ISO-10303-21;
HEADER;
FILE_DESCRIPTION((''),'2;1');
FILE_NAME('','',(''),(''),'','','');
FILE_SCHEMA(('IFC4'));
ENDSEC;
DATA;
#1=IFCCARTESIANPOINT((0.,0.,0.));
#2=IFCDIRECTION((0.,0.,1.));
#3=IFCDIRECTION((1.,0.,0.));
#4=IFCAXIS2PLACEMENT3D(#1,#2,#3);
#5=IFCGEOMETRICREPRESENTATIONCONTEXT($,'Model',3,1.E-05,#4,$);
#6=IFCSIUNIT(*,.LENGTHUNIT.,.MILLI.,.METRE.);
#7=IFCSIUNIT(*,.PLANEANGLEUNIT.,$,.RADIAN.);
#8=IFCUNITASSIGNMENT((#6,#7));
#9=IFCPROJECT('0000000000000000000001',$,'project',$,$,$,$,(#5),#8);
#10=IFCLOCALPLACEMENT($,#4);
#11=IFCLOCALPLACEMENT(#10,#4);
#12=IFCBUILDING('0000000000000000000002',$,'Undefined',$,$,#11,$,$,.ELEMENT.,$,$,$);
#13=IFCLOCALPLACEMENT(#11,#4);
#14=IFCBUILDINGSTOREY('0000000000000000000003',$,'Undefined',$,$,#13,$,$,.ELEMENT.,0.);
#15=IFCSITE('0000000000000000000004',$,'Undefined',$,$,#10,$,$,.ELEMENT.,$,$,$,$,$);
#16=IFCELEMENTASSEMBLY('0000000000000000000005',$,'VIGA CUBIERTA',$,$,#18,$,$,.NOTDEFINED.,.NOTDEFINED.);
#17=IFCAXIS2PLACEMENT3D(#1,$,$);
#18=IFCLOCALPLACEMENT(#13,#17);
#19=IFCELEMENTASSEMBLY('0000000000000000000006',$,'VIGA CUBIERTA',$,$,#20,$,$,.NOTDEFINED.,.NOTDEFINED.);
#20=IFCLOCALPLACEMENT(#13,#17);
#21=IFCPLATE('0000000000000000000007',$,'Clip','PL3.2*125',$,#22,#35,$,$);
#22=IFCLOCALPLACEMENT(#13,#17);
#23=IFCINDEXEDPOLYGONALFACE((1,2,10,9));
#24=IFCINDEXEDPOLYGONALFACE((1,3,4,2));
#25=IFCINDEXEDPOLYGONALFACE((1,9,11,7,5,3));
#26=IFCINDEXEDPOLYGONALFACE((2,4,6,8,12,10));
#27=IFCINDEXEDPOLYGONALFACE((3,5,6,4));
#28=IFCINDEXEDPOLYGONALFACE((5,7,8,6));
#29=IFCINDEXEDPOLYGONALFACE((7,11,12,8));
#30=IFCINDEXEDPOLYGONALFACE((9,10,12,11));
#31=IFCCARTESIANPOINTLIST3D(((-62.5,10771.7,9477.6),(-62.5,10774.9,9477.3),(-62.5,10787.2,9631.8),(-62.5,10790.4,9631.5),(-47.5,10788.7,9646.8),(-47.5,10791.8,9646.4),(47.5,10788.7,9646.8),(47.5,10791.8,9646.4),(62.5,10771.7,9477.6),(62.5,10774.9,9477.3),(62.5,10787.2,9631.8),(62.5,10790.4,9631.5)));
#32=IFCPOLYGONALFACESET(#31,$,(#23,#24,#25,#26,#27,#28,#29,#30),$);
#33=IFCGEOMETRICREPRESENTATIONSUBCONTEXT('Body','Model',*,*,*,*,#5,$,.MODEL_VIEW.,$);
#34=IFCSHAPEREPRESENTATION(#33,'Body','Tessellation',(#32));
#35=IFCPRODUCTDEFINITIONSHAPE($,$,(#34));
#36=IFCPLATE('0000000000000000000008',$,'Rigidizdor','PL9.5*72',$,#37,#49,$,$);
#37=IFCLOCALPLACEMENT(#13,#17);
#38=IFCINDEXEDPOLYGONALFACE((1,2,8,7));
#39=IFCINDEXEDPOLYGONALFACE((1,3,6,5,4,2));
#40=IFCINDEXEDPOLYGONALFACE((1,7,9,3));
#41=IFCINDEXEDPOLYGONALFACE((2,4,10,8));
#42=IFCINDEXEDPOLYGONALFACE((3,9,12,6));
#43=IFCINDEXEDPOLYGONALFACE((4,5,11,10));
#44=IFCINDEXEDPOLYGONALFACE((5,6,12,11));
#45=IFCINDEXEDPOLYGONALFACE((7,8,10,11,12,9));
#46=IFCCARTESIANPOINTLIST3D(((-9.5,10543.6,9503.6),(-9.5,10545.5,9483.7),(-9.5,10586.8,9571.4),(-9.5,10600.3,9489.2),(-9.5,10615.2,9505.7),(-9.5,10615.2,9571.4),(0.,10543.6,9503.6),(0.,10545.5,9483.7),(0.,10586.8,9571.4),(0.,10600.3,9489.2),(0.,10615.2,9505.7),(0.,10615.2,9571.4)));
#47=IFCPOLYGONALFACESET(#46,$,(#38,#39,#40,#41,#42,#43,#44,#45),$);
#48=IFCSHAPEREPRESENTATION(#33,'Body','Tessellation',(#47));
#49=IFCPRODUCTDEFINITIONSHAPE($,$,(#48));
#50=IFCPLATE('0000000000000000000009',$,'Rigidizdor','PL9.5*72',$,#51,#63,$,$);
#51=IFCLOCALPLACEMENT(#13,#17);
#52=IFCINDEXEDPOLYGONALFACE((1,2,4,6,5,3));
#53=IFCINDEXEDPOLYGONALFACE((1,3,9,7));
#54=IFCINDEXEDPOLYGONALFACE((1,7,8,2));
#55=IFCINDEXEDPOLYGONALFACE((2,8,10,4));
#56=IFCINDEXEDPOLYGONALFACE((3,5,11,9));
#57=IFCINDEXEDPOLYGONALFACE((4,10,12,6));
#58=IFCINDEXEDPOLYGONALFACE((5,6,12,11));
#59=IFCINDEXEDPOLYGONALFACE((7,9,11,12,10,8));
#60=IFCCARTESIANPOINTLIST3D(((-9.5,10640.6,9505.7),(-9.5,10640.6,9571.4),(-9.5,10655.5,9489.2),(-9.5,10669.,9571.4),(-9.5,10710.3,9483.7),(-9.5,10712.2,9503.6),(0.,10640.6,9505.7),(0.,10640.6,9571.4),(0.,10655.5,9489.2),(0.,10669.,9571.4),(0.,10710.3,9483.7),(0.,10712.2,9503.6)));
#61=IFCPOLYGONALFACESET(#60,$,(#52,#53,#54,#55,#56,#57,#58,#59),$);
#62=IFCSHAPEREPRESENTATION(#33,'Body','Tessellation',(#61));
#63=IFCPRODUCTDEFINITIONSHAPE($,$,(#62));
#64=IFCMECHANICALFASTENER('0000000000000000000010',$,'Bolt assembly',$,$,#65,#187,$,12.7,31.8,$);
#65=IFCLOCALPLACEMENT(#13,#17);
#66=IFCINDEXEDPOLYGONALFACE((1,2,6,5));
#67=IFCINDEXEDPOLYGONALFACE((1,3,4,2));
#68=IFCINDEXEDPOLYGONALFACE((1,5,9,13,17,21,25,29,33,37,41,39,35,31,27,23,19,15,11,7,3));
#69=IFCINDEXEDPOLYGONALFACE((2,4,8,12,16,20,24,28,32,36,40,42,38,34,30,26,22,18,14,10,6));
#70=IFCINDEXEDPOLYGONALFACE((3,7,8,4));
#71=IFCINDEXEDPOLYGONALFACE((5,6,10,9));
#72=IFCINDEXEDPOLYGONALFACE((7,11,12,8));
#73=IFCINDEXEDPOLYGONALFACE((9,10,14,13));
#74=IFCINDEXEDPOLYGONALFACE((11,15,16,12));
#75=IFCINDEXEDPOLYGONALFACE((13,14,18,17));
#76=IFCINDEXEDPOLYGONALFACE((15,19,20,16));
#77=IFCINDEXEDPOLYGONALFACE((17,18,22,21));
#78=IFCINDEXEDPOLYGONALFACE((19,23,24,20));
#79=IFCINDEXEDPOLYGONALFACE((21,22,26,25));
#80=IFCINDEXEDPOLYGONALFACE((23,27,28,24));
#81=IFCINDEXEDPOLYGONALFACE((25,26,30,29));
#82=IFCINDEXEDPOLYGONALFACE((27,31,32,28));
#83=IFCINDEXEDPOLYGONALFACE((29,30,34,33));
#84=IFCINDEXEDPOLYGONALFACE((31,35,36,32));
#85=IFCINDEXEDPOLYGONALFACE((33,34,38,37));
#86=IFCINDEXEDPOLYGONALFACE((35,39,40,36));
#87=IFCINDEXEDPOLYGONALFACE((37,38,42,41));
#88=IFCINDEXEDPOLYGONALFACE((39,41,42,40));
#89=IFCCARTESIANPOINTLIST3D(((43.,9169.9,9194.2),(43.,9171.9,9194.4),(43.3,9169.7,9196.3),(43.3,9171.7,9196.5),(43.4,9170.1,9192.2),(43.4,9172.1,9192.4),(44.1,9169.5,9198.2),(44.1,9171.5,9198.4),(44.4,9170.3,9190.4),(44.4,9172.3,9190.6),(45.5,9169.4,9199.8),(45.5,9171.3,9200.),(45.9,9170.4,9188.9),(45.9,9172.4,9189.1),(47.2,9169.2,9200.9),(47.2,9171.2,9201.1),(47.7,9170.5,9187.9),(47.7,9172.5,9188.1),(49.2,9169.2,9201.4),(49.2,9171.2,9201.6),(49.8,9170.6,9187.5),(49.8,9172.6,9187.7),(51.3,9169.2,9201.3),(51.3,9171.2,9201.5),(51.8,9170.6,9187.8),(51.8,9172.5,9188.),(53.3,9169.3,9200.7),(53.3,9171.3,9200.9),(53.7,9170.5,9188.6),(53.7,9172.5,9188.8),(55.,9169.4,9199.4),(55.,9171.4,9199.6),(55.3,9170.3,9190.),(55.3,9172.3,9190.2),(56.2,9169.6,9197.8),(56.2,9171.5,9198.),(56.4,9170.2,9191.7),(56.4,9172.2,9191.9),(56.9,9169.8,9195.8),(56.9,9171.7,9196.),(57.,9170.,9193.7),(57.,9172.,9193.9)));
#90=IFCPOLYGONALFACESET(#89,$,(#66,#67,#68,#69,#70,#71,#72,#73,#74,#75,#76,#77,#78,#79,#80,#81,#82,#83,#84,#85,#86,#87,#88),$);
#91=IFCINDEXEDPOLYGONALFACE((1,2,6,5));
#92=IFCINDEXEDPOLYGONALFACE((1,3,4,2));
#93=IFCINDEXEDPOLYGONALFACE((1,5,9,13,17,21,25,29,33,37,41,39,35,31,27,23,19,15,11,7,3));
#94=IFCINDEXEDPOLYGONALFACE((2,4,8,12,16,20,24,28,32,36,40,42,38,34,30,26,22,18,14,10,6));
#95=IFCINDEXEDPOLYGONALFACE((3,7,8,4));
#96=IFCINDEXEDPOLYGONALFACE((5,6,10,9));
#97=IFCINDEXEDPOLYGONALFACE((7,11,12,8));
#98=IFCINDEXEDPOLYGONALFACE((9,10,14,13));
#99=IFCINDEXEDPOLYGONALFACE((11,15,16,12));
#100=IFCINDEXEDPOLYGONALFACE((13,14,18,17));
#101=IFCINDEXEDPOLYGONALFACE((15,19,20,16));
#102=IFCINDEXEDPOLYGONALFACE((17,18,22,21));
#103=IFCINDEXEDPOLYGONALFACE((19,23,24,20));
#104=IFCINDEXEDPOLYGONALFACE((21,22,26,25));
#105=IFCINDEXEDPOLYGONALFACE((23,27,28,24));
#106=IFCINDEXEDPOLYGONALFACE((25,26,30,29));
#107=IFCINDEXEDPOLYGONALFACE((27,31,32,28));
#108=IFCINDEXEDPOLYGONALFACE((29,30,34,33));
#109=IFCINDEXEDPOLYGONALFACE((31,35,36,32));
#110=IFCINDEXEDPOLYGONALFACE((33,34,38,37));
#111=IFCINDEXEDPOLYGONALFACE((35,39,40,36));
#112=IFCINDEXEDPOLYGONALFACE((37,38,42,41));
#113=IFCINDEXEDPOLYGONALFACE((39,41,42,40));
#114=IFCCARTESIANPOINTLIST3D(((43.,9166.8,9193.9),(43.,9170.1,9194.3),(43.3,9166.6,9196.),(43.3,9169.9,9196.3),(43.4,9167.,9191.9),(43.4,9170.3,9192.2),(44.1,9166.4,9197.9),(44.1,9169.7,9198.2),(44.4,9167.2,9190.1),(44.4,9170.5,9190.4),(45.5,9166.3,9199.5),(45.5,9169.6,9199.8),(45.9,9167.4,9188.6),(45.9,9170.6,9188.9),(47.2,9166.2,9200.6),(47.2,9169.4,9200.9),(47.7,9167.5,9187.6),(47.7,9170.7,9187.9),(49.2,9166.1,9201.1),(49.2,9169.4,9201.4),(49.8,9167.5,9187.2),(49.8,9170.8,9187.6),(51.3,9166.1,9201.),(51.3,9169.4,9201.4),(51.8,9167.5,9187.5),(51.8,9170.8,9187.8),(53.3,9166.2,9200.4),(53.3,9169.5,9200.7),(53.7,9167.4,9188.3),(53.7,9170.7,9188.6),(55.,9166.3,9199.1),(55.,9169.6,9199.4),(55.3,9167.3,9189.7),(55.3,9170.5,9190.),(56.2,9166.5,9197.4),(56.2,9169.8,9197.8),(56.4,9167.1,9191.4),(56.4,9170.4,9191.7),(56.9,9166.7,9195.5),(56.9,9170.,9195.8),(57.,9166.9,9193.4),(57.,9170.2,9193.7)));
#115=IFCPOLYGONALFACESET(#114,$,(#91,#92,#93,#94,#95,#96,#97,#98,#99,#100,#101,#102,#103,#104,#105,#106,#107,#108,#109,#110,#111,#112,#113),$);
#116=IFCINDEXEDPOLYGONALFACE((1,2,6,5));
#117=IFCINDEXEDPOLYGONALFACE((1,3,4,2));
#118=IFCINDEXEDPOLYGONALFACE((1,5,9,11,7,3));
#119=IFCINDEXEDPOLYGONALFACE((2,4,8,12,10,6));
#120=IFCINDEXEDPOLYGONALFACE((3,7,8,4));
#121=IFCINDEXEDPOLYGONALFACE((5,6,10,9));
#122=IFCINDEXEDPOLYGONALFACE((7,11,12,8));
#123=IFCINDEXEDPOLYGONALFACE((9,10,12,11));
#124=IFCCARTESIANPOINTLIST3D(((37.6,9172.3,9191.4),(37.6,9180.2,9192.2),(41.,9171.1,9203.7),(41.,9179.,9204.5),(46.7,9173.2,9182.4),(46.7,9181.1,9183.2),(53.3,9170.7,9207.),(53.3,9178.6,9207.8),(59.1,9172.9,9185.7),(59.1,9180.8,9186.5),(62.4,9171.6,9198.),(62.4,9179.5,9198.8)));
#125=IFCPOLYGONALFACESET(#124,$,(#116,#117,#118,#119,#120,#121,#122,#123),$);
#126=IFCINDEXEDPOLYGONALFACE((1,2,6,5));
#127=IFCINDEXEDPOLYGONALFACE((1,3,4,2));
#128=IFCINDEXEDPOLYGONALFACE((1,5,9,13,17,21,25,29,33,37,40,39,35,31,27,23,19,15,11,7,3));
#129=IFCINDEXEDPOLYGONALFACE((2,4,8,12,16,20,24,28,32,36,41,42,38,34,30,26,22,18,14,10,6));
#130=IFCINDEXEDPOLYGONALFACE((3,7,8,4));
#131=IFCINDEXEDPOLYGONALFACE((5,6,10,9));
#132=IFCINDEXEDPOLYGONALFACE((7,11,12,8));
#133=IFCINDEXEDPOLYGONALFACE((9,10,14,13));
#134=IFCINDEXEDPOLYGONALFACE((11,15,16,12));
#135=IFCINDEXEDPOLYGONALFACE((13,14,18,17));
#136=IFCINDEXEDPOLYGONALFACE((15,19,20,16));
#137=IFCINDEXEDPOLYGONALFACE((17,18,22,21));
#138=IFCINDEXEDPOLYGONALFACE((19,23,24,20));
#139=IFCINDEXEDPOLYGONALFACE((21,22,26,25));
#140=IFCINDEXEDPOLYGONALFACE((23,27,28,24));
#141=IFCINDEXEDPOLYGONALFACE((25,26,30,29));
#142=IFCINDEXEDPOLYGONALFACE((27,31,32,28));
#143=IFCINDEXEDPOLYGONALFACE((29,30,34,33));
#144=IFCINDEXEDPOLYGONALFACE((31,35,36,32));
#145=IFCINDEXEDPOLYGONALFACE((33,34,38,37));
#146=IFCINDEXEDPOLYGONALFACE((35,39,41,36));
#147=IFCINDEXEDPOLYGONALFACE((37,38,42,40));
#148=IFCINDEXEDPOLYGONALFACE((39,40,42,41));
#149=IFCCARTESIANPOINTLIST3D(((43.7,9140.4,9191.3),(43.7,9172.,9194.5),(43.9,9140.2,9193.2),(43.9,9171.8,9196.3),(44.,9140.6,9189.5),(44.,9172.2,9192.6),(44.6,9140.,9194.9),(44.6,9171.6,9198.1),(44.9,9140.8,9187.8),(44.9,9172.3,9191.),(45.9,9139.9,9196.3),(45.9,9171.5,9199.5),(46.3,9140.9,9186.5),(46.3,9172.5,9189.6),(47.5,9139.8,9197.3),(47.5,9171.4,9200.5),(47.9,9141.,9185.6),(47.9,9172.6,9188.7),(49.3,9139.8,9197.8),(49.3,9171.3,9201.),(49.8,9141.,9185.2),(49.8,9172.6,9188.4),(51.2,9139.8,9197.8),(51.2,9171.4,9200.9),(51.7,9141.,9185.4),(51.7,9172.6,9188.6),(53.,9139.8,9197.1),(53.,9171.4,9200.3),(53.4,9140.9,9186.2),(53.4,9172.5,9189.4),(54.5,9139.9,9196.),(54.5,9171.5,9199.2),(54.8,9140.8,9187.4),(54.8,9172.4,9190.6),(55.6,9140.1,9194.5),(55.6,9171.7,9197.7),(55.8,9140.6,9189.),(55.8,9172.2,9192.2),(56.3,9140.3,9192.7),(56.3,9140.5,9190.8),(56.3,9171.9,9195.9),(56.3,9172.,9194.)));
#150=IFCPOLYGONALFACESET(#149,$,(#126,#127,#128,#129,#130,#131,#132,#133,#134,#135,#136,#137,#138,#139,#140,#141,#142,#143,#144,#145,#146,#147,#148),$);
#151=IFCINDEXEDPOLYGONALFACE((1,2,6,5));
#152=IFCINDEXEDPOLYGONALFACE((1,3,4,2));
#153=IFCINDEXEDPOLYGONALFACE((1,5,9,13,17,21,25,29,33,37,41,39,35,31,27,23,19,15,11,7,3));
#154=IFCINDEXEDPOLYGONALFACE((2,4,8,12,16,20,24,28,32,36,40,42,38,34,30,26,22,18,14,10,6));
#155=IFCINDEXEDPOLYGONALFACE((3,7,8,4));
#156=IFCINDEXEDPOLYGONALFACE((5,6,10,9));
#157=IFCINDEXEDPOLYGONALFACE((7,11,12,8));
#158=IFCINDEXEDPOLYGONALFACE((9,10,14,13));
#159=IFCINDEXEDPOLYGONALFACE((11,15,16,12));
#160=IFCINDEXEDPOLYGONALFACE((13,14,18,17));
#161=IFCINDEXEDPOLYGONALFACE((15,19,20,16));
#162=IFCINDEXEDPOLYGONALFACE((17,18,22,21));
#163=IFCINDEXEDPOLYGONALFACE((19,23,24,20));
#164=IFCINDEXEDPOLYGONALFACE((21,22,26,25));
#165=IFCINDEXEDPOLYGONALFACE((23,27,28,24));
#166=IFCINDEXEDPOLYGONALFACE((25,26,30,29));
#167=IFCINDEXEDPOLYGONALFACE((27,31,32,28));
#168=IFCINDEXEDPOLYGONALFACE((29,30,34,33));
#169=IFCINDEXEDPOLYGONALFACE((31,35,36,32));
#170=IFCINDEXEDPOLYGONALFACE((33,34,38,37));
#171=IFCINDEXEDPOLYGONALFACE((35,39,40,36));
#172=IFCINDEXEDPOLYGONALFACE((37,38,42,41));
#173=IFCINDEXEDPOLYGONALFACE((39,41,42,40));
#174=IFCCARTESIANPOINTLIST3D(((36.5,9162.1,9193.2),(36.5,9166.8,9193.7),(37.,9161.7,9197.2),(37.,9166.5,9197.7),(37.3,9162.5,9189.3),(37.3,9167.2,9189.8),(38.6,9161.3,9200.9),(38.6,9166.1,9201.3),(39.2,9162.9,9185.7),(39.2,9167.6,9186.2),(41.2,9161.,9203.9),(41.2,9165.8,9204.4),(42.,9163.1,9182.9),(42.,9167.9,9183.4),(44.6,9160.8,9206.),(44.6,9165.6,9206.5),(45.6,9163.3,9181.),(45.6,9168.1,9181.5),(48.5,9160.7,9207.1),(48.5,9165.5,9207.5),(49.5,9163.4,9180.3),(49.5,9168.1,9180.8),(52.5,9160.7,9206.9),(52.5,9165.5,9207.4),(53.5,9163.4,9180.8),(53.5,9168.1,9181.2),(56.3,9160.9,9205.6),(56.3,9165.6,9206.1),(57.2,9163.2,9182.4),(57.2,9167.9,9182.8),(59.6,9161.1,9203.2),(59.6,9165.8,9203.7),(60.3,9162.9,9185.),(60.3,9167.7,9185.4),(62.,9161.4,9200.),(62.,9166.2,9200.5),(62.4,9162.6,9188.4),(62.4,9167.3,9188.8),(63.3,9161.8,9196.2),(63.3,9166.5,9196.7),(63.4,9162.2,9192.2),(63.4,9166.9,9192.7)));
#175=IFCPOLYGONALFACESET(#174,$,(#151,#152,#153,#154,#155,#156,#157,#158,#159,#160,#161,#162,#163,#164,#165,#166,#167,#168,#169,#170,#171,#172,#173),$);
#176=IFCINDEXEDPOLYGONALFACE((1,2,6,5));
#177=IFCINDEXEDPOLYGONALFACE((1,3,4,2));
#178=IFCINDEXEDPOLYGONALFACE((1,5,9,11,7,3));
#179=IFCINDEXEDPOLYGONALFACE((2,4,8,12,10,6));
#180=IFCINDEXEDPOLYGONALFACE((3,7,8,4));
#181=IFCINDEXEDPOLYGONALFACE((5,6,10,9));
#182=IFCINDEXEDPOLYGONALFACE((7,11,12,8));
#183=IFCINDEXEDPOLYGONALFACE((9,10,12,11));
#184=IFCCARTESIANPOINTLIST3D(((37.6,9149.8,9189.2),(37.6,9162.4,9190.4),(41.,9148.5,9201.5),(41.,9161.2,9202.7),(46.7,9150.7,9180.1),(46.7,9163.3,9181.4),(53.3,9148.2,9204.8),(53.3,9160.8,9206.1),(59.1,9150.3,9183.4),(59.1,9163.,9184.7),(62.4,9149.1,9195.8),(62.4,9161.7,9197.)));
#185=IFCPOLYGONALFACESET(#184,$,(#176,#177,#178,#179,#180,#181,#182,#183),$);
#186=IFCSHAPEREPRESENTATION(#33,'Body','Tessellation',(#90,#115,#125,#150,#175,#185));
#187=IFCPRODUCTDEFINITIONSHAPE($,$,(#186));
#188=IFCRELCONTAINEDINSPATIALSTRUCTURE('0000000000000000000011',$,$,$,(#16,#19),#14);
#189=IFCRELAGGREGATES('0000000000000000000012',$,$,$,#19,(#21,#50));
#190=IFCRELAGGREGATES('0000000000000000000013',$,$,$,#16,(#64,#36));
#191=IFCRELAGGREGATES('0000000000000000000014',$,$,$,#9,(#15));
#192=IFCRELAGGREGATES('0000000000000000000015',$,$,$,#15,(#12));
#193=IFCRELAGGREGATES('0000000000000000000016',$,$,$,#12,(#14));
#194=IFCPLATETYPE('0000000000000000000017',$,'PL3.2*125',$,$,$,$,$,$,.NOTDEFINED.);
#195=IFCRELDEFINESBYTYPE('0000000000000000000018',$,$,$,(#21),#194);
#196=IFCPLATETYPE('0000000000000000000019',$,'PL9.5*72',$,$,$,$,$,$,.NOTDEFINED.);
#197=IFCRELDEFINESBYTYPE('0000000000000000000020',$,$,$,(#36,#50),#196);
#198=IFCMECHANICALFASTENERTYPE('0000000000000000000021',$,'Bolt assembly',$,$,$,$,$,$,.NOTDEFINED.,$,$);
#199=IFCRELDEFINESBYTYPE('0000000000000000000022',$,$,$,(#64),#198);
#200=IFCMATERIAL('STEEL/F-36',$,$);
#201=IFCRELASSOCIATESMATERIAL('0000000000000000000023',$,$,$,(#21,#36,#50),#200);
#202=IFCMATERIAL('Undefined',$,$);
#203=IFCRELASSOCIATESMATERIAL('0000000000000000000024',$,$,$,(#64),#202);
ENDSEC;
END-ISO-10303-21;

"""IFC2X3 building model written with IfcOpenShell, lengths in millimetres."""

from ifc_helpers import new_model, si_unit, frame, origin_with_axes, origin_2d_with_axis, place, context, subcontext, project, spatial, polyline, circle, outline, extrude, source, transform, mapped, material, type_object, element, aggregate, save


model = new_model("IFC2X3")

# Units and contexts
model_context = context("Model", 3, precision=1e-05, world=origin_with_axes())
body_context = subcontext(model_context, "Body", "Model", "MODEL_VIEW")
ifc_project = project(units=[si_unit("LENGTHUNIT", "METRE", prefix="MILLI"), si_unit("PLANEANGLEUNIT", "RADIAN")], contexts=[model_context])

# Site, building, storey
site_placement = place(None, origin_with_axes())
site = spatial("IfcSite", under=ifc_project, at=site_placement, Name="Undefined", CompositionType="ELEMENT")
building_placement = place(site_placement, origin_with_axes())
building = spatial("IfcBuilding", under=site, at=building_placement, Name="Undefined", CompositionType="ELEMENT")
storey_placement = place(building_placement, origin_with_axes())
storey = spatial("IfcBuildingStorey", under=building, at=storey_placement, Name="Undefined", CompositionType="ELEMENT", Elevation=0.0)

# Element assemblies
assembly_1_placement = place(storey_placement, origin_with_axes())
assembly_1 = element("IfcElementAssembly", 1, at=assembly_1_placement, inside=storey, Name="VIGA CUBIERTA", AssemblyPlace="NOTDEFINED", PredefinedType="NOTDEFINED")
ifc_material_1 = material(Name="STEEL/F-36")
assembly_2_placement = place(storey_placement, origin_with_axes())
assembly_2 = element("IfcElementAssembly", 2, at=assembly_2_placement, inside=storey, Name="VIGA CUBIERTA", AssemblyPlace="NOTDEFINED", PredefinedType="NOTDEFINED")

# Plates
plate_type_1 = type_object("IfcPlateType", Name="PL3.2*125", PredefinedType="NOTDEFINED")
plate_1_placement = place(assembly_2_placement, frame((62.5, 10773.3, 9477.4), z_axis=(0.0, 0.995037, -0.099504), x_axis=(-1.0, 0.0, 0.0)))
plate_1 = element("IfcPlate", 3, at=plate_1_placement, type_object=plate_type_1, material=ifc_material_1, Name="Clip", Description="PL3.2*125", context=body_context, shape_type="SweptSolid", body=[
    extrude(outline(polyline([(0.0, 0.0), (125.0, 0.0), (125.0, 155.0), (110.0, 170.0), (15.0, 170.0), (0.0, 155.0), (0.0, 0.0)])), frame((0.0, 0.0, -1.6), z_axis=(0.0, 0.0, 1.0), x_axis=(1.0, 0.0, 0.0)), (0.0, 0.0, 1.0), 3.2),
])
plate_type_2 = type_object("IfcPlateType", Name="PL9.5*72", PredefinedType="NOTDEFINED")
plate_2_placement = place(assembly_1_placement, frame((-4.8, 10586.8, 9571.4), z_axis=(-1.0, 0.0, 0.0), x_axis=(0.0, 1.0, 0.000007)))
plate_2 = element("IfcPlate", 4, at=plate_2_placement, type_object=plate_type_2, material=ifc_material_1, Name="Rigidizdor", Description="PL9.5*72", context=body_context, shape_type="SweptSolid", body=[
    extrude(outline(polyline([(0.0, 0.0), (28.4, 0.0), (28.4, 65.7), (13.5, 82.2), (-41.3, 87.7), (-43.2, 67.8), (0.0, 0.0)])), frame((0.0, 0.0, -4.7), z_axis=(0.0, 0.0, 1.0), x_axis=(1.0, 0.0, 0.0)), (0.0, 0.0, 1.0), 9.5),
])
plate_3_placement = place(assembly_2_placement, frame((-4.7, 10669.0, 9571.4), z_axis=(1.0, 0.0, 0.0), x_axis=(0.0, -1.0, 0.000007)))
plate_3 = element("IfcPlate", 5, at=plate_3_placement, type_object=plate_type_2, material=ifc_material_1, Name="Rigidizdor", Description="PL9.5*72", context=body_context, shape_type="SweptSolid", body=[
    extrude(outline(polyline([(0.0, 0.0), (28.4, 0.0), (28.4, 65.7), (13.5, 82.2), (-41.3, 87.7), (-43.2, 67.8), (0.0, 0.0)])), frame((0.0, 0.0, -4.7), z_axis=(0.0, 0.0, 1.0), x_axis=(1.0, 0.0, 0.0)), (0.0, 0.0, 1.0), 9.5),
])
aggregate(assembly_2, [plate_1, plate_3])

# Shared definitions
ifc_material_2 = material(Name="Undefined")
mechanical_fastener_type = type_object("IfcMechanicalFastenerType", Name="Bolt assembly")

# Mechanical fastener
shared_shape_1 = source(origin_with_axes(), body_context, "Body", "SweptSolid", [
    extrude(circle(Radius=7.0, at=origin_2d_with_axis()), frame((0.0, -1.9, 0.0), z_axis=(0.0, 1.0, 0.0), x_axis=(1.0, 0.0, 0.0)), (0.0, 0.0, 1.0), 2.0),
    extrude(circle(Radius=7.0, at=origin_2d_with_axis()), frame((0.0, -0.1, 0.0), z_axis=(0.0, 1.0, 0.0), x_axis=(1.0, 0.0, 0.0)), (0.0, 0.0, 1.0), 3.3),
    extrude(outline(polyline([(11.1, -6.4), (11.1, 6.4), (0.0, 12.8), (-11.1, 6.4), (-11.1, -6.4), (0.0, -12.8), (11.1, -6.4)])), frame((0.0, -9.9, 0.0), z_axis=(0.0, 1.0, 0.0), x_axis=(1.0, 0.0, 0.0)), (0.0, 0.0, 1.0), 7.9),
    extrude(circle(Radius=6.3, at=origin_2d_with_axis()), frame((0.0, -2.0, 0.0), z_axis=(0.0, 1.0, 0.0), x_axis=(1.0, 0.0, 0.0)), (0.0, 0.0, 1.0), 31.8),
    extrude(circle(Radius=13.5, at=origin_2d_with_axis()), frame((0.0, 3.2, 0.0), z_axis=(0.0, 1.0, 0.0), x_axis=(1.0, 0.0, 0.0)), (0.0, 0.0, 1.0), 4.8),
    extrude(outline(polyline([(11.1, -6.4), (11.1, 6.4), (0.0, 12.8), (-11.1, 6.4), (-11.1, -6.4), (0.0, -12.8), (11.1, -6.4)])), frame((0.0, 8.0, 0.0), z_axis=(0.0, 1.0, 0.0), x_axis=(1.0, 0.0, 0.0)), (0.0, 0.0, 1.0), 12.7),
])
mechanical_fastener_1_placement = place(assembly_1_placement, frame((50.0, 9170.0, 9194.5), z_axis=(0.707107, 0.07036, -0.703598), x_axis=(0.707107, -0.07036, 0.703598)))
mechanical_fastener_1 = element("IfcMechanicalFastener", 6, at=mechanical_fastener_1_placement, type_object=mechanical_fastener_type, material=ifc_material_2, Name="Bolt assembly", NominalDiameter=12.7, NominalLength=31.8, context=body_context, shape_type="MappedRepresentation", body=[
    mapped(shared_shape_1, transform((0.0, 0.0, 0.0))),
])

aggregate(assembly_1, [mechanical_fastener_1, plate_2])

save(model, "model.ifc")
